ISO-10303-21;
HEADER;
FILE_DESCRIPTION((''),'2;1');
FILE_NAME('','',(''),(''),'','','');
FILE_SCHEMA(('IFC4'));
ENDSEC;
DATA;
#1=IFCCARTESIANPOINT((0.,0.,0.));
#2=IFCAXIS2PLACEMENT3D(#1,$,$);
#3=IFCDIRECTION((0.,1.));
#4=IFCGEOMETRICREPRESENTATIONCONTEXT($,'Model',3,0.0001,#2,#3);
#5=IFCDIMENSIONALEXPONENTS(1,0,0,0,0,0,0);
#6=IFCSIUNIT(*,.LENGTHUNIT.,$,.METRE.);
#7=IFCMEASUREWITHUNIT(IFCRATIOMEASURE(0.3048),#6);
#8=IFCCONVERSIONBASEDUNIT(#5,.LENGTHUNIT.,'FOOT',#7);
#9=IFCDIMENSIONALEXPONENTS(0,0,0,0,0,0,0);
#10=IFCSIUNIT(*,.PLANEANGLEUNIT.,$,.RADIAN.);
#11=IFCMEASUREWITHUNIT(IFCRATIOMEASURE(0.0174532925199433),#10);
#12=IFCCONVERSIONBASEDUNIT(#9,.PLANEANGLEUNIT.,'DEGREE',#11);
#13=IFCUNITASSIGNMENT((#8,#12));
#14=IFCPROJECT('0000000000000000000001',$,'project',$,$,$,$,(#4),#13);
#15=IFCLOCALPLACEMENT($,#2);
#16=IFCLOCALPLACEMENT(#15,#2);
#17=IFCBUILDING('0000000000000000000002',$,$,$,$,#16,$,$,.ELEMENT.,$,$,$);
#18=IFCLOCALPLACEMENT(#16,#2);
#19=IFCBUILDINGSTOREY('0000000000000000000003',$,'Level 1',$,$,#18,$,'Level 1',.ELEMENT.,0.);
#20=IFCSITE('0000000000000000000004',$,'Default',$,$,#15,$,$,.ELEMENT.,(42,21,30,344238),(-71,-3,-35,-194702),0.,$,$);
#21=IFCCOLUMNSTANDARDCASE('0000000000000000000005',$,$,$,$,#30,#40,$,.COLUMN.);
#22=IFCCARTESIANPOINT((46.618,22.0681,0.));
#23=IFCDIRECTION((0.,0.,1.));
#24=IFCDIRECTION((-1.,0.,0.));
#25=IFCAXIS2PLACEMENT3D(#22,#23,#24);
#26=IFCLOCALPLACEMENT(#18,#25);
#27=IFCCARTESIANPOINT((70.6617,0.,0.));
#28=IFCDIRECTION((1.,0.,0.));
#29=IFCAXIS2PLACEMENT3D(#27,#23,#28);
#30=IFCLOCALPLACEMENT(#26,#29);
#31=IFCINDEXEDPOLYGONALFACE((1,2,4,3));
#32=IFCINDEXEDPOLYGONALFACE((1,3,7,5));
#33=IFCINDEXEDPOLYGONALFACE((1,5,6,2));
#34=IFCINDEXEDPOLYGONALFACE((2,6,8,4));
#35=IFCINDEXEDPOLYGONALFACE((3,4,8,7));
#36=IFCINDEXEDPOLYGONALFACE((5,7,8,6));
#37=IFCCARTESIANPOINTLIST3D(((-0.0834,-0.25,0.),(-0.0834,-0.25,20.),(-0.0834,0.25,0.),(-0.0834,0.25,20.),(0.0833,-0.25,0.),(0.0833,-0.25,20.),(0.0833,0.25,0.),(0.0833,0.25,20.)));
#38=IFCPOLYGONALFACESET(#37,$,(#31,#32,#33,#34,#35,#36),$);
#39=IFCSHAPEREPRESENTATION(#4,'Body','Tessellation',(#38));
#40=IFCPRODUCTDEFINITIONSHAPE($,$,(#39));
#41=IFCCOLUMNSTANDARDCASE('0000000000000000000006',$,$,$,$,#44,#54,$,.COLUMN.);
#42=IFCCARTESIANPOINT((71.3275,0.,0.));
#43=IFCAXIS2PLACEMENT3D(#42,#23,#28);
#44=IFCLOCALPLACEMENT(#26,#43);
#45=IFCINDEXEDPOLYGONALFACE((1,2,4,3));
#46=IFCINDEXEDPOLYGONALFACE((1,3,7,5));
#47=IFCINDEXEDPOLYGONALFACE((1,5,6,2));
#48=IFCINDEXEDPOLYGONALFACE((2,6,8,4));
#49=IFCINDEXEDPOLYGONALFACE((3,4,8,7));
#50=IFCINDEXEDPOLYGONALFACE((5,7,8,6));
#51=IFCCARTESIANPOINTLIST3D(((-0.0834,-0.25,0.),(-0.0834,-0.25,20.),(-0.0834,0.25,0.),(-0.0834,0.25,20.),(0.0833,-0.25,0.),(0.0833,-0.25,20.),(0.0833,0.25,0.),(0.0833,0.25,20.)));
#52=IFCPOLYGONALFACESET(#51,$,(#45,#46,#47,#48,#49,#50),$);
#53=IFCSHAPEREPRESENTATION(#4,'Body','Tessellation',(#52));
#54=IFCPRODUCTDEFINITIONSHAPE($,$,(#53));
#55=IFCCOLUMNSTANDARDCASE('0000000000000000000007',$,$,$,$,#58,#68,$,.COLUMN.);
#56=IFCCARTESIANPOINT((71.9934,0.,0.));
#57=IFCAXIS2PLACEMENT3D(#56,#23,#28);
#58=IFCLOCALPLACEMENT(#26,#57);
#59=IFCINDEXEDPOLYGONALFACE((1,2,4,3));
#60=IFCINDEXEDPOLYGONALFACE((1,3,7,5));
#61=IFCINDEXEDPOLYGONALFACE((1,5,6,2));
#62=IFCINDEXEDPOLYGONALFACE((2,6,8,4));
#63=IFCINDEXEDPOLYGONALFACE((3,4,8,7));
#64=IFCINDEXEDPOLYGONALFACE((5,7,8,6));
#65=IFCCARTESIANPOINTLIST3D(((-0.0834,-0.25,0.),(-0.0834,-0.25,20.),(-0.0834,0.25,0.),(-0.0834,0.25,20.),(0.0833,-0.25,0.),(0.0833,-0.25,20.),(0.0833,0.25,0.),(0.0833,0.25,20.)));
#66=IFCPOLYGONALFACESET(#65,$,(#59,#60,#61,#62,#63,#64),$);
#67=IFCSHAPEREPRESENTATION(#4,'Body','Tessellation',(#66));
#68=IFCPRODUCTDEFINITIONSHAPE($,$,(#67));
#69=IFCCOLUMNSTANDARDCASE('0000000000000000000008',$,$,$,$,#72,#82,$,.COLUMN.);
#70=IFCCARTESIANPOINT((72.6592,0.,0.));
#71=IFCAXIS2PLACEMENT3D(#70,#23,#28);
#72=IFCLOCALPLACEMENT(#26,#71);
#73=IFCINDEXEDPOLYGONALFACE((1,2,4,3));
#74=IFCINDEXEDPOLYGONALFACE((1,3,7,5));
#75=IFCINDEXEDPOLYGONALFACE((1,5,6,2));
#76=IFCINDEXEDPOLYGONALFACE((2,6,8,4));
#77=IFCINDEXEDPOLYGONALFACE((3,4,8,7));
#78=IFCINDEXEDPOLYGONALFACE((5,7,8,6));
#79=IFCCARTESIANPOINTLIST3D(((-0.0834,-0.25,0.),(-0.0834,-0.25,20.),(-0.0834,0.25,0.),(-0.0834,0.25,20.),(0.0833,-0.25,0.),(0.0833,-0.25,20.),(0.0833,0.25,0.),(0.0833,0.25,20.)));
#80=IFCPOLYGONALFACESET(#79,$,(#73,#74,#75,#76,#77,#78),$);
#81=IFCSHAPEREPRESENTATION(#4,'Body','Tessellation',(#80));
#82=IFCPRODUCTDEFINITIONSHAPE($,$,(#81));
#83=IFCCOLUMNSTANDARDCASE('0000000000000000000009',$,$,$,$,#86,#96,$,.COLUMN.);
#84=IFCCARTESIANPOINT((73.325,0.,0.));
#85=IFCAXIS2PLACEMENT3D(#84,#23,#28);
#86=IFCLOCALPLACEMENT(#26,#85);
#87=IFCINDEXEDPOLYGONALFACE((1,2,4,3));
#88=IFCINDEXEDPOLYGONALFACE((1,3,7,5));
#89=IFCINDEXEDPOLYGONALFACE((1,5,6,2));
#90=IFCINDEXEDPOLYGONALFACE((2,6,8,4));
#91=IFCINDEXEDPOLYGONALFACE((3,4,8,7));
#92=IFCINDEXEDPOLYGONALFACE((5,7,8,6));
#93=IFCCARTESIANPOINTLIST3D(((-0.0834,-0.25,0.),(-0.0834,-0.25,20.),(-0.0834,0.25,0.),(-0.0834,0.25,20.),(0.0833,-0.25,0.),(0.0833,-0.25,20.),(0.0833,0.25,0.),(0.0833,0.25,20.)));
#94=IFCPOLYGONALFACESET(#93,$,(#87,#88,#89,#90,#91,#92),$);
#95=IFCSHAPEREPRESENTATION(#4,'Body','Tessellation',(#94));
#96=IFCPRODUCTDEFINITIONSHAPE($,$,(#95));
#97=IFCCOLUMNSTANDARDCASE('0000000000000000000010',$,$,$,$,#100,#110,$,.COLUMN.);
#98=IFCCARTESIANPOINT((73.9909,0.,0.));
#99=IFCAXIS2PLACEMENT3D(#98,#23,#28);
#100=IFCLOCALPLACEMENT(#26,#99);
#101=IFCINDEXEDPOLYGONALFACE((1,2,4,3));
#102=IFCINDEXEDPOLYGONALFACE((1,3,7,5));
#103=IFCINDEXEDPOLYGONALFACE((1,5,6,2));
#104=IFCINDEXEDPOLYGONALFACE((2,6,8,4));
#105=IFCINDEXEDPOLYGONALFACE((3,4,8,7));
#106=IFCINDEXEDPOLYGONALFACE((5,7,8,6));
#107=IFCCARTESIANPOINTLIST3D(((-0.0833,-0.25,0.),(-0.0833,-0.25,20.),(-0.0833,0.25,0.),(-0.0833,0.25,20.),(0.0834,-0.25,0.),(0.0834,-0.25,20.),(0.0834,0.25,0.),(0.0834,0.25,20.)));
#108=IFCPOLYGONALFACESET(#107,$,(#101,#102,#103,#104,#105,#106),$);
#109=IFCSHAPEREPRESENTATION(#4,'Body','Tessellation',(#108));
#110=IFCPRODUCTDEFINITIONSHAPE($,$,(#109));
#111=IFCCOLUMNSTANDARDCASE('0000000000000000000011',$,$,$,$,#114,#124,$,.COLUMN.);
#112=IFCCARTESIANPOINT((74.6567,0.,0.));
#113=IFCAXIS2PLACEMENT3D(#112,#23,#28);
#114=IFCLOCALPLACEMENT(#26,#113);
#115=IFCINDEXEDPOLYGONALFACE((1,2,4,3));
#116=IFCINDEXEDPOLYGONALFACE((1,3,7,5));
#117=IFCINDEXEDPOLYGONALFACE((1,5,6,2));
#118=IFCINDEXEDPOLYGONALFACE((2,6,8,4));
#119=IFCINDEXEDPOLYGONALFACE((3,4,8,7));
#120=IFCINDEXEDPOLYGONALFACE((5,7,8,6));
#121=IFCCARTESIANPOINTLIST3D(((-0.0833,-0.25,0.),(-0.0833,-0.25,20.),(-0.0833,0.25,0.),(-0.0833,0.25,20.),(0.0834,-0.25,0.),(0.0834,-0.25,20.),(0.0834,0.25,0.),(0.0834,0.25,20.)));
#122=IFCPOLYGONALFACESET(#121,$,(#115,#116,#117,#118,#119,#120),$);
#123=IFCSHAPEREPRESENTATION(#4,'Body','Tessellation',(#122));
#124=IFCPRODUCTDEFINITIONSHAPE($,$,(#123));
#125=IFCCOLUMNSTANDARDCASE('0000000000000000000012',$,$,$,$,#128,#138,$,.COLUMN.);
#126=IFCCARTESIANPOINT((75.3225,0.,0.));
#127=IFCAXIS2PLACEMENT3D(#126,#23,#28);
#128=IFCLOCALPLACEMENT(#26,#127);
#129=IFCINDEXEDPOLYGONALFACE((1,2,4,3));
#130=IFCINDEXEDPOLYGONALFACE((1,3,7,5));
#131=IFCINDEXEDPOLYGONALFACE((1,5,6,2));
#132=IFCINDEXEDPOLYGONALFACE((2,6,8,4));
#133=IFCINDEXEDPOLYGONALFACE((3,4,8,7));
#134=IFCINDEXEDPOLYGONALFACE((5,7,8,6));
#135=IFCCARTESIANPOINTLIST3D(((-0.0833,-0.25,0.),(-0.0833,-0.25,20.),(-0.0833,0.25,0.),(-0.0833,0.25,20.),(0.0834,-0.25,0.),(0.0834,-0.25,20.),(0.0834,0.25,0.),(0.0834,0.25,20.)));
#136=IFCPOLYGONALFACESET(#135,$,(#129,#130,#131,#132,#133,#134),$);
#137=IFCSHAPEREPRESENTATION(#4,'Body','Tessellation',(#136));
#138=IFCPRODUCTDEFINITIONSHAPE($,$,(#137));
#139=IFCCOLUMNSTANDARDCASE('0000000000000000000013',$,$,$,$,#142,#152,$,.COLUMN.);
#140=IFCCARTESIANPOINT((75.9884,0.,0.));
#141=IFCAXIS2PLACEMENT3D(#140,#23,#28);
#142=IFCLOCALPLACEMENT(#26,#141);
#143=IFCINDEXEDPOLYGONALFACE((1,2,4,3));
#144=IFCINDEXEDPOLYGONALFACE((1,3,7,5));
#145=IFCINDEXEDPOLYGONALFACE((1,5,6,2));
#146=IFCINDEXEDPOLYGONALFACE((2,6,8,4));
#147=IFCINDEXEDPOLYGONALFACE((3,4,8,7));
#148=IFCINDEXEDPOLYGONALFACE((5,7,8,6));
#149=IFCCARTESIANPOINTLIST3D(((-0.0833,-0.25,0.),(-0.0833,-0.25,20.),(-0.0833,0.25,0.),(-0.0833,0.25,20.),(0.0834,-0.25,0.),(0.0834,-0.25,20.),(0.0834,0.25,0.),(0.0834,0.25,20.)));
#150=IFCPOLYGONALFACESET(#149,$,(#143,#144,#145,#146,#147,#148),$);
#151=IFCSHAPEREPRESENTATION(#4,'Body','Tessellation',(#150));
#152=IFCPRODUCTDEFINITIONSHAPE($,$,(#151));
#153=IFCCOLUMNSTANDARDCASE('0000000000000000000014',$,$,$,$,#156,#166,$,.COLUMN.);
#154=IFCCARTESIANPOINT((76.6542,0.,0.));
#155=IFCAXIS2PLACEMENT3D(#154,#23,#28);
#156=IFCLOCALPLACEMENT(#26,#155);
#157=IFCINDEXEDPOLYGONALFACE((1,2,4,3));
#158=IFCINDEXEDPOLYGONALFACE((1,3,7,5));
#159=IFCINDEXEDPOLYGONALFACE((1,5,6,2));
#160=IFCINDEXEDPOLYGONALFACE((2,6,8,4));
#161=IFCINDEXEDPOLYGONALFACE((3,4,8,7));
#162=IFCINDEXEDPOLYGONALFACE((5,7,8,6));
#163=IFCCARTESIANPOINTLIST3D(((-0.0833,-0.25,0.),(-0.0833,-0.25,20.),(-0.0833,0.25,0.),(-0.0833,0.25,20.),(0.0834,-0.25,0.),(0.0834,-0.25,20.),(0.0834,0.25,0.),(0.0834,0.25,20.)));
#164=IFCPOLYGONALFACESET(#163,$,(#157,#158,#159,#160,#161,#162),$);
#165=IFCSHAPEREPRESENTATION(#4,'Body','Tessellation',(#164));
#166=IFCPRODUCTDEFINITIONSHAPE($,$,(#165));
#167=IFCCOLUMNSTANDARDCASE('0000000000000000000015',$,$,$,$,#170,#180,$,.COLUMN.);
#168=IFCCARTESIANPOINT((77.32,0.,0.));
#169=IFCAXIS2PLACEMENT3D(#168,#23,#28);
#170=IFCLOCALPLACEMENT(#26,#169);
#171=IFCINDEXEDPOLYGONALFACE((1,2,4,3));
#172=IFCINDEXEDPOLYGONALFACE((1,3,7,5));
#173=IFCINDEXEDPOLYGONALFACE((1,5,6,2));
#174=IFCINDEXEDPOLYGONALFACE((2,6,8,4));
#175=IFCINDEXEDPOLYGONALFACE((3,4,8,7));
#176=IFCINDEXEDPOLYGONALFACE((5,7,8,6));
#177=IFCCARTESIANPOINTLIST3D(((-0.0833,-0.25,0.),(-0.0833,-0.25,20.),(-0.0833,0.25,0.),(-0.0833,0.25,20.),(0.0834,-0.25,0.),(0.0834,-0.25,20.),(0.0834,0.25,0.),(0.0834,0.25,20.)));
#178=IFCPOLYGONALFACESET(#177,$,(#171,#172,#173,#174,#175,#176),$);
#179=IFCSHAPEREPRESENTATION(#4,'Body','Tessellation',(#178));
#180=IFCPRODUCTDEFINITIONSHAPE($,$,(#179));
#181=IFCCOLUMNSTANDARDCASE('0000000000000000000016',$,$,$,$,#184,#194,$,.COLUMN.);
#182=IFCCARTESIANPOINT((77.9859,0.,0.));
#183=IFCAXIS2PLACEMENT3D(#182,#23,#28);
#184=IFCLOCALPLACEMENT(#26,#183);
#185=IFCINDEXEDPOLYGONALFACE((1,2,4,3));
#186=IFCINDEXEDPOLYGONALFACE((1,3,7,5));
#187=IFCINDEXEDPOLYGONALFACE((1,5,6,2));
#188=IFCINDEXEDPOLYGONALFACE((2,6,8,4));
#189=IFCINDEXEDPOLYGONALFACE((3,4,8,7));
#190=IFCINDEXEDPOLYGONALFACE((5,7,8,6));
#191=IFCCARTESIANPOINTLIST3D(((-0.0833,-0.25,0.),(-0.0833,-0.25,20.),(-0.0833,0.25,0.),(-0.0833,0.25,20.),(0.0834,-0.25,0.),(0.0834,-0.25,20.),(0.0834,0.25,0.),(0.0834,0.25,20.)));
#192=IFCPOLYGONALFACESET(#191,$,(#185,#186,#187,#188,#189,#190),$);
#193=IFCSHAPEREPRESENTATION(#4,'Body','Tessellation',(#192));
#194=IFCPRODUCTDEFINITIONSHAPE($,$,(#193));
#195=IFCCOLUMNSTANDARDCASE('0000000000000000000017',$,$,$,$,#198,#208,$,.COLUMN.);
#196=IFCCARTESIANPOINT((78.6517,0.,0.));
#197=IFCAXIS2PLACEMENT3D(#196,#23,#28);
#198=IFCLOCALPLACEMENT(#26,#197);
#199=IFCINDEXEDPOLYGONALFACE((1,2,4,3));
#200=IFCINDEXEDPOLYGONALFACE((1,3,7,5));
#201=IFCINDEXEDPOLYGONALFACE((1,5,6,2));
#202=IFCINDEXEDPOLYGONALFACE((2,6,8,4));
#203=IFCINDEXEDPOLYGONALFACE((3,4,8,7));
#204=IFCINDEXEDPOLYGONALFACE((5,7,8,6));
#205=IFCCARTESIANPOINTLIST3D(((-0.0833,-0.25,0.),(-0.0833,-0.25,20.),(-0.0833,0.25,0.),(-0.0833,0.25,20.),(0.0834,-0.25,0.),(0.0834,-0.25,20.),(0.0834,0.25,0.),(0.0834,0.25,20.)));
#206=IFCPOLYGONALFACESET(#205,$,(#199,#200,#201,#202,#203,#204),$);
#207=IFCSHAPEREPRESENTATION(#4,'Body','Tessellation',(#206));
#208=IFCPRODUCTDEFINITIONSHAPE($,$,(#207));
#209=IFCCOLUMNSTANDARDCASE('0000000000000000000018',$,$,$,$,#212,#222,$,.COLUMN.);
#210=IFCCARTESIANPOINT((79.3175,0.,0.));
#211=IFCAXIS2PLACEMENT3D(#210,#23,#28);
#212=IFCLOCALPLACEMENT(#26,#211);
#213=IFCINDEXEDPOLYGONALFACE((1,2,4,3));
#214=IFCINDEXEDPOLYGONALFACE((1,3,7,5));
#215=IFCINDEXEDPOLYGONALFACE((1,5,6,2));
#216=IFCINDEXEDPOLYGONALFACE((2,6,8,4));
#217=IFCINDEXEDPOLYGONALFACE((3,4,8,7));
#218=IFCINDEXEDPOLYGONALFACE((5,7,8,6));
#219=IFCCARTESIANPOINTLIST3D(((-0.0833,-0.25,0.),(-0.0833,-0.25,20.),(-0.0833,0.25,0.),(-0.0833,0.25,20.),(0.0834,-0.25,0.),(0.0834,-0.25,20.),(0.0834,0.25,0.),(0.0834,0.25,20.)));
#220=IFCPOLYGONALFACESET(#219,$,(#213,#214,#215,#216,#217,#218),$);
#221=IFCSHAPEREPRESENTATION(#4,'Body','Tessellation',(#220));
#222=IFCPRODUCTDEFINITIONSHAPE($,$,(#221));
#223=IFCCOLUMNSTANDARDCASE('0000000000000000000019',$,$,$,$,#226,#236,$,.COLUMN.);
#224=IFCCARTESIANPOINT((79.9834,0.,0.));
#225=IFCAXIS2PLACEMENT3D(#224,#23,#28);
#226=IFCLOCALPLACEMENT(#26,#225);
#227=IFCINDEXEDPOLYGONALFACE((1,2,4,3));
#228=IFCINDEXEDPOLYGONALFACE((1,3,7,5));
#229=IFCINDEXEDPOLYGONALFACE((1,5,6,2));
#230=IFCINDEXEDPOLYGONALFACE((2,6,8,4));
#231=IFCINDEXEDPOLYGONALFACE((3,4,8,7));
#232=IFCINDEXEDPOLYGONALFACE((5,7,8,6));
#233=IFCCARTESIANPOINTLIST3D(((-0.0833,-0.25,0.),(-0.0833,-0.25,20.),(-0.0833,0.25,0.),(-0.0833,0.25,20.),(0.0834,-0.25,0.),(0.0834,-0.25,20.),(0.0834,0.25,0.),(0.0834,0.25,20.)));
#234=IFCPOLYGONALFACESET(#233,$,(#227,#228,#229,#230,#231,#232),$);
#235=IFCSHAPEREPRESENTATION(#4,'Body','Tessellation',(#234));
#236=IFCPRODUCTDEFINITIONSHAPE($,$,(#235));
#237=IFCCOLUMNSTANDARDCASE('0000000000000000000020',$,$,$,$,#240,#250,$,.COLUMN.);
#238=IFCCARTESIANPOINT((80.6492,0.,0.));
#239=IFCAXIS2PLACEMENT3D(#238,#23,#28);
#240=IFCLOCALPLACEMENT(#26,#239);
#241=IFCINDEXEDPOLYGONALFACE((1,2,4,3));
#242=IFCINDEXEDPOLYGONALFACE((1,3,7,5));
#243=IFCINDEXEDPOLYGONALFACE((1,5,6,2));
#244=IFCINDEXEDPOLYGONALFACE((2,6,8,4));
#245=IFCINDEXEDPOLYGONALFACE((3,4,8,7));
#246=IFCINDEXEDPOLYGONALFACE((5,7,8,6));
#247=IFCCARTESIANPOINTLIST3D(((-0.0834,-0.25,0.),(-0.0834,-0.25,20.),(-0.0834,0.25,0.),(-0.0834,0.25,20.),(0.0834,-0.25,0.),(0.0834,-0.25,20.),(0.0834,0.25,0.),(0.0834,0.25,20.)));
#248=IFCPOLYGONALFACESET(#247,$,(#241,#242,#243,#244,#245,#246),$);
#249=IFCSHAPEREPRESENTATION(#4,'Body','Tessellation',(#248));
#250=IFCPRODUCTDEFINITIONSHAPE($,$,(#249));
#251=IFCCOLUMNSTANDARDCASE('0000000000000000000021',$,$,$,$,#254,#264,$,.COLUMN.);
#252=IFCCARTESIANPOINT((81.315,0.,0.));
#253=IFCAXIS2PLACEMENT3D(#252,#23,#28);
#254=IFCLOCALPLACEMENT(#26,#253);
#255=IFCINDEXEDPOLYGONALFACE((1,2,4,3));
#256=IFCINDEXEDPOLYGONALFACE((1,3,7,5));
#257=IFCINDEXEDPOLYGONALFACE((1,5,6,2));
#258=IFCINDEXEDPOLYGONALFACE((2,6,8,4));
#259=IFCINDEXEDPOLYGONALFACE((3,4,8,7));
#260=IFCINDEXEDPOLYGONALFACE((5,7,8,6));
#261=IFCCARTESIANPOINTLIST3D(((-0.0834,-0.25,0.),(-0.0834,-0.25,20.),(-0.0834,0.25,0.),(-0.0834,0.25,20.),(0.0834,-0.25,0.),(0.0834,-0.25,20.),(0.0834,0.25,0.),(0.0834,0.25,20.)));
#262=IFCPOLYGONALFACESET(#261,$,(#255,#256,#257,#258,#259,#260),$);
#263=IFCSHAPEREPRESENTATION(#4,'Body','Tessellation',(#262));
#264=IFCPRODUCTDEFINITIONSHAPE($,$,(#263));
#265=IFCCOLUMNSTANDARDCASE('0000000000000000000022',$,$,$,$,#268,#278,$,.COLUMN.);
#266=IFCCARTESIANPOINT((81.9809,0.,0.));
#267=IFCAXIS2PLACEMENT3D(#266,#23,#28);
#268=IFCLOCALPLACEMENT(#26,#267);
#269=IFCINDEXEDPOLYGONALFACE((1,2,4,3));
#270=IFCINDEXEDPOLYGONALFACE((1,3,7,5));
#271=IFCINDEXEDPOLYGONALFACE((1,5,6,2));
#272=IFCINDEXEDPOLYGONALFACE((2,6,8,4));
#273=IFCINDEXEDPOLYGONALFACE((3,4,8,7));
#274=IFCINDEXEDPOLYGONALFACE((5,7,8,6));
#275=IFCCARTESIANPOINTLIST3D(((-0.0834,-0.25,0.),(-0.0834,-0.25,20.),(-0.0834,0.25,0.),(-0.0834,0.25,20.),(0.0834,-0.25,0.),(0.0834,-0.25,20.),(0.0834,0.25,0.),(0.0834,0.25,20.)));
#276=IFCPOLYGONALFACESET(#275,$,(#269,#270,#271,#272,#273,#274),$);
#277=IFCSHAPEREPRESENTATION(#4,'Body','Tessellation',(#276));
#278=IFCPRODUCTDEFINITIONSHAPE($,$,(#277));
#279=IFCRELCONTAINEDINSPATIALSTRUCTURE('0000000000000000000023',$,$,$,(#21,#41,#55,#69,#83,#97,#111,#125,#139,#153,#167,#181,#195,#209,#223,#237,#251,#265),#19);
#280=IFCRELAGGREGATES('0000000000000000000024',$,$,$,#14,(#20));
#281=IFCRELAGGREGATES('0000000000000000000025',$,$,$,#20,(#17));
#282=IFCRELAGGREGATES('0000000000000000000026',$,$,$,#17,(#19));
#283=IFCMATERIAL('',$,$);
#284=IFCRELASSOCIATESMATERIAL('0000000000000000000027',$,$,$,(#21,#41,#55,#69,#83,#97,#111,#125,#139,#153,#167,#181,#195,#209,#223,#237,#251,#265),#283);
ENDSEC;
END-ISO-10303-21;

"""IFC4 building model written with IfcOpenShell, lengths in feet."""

from ifc_helpers import new_model, entity, si_unit, converted_unit, direction, frame, origin, place, context, project, spatial, rectangle, extrude, material, element, save


model = new_model("IFC4")

# Units and contexts
model_context = context("Model", 3, precision=0.0001, world=origin(), true_north=direction((0.0, 1.0)))
ifc_project = project(units=[converted_unit("LENGTHUNIT", "FOOT", entity("IfcRatioMeasure", 0.3048), si_unit("LENGTHUNIT", "METRE"), dimensions=[1, 0, 0, 0, 0, 0, 0]), converted_unit("PLANEANGLEUNIT", "DEGREE", entity("IfcRatioMeasure", 0.0174532925199433), si_unit("PLANEANGLEUNIT", "RADIAN"), dimensions=[0, 0, 0, 0, 0, 0, 0])], contexts=[model_context])

# Site, building, storey
site_placement = place(None, origin())
site = spatial("IfcSite", under=ifc_project, at=site_placement, Name="Default", CompositionType="ELEMENT", RefLatitude=(42, 21, 30, 344238), RefLongitude=(-71, -3, -35, -194702), RefElevation=0.0)
building_placement = place(site_placement, origin())
building = spatial("IfcBuilding", under=site, at=building_placement, CompositionType="ELEMENT")
storey_placement = place(building_placement, origin())
storey = spatial("IfcBuildingStorey", under=building, at=storey_placement, Name="Level 1", LongName="Level 1", CompositionType="ELEMENT", Elevation=0.0)

# Columns
ifc_material = material(Name="")
placement = place(storey_placement, frame((46.618, 22.0681, 0.0), z_axis=(0.0, 0.0, 1.0), x_axis=(-1.0, 0.0, 0.0)))
for number, where, z_axis, x_axis in (
    (1, (70.6617, 0.0, 0.0), (0.0, 0.0, 1.0), (1.0, 0.0, 0.0)),
    (2, (71.3275, 0.0, 0.0), (0.0, 0.0, 1.0), (1.0, 0.0, 0.0)),
    (3, (71.9934, 0.0, 0.0), (0.0, 0.0, 1.0), (1.0, 0.0, 0.0)),
    (4, (72.6592, 0.0, 0.0), (0.0, 0.0, 1.0), (1.0, 0.0, 0.0)),
    (5, (73.325, 0.0, 0.0), (0.0, 0.0, 1.0), (1.0, 0.0, 0.0)),
    (6, (73.9909, 0.0, 0.0), (0.0, 0.0, 1.0), (1.0, 0.0, 0.0)),
    (7, (74.6567, 0.0, 0.0), (0.0, 0.0, 1.0), (1.0, 0.0, 0.0)),
    (8, (75.3225, 0.0, 0.0), (0.0, 0.0, 1.0), (1.0, 0.0, 0.0)),
    (9, (75.9884, 0.0, 0.0), (0.0, 0.0, 1.0), (1.0, 0.0, 0.0)),
    (10, (76.6542, 0.0, 0.0), (0.0, 0.0, 1.0), (1.0, 0.0, 0.0)),
    (11, (77.32, 0.0, 0.0), (0.0, 0.0, 1.0), (1.0, 0.0, 0.0)),
    (12, (77.9859, 0.0, 0.0), (0.0, 0.0, 1.0), (1.0, 0.0, 0.0)),
    (13, (78.6517, 0.0, 0.0), (0.0, 0.0, 1.0), (1.0, 0.0, 0.0)),
    (14, (79.3175, 0.0, 0.0), (0.0, 0.0, 1.0), (1.0, 0.0, 0.0)),
    (15, (79.9834, 0.0, 0.0), (0.0, 0.0, 1.0), (1.0, 0.0, 0.0)),
    (16, (80.6492, 0.0, 0.0), (0.0, 0.0, 1.0), (1.0, 0.0, 0.0)),
    (17, (81.315, 0.0, 0.0), (0.0, 0.0, 1.0), (1.0, 0.0, 0.0)),
    (18, (81.9809, 0.0, 0.0), (0.0, 0.0, 1.0), (1.0, 0.0, 0.0)),
):
    element("IfcColumnStandardCase", number, at=place(placement, frame(where, z_axis=z_axis, x_axis=x_axis)), inside=storey, material=ifc_material, PredefinedType="COLUMN", context=model_context, shape_type="SweptSolid", body=[
        extrude(rectangle(XDim=0.1667, YDim=0.5), origin(), (0.0, 0.0, 1.0), 20.0),
    ])

save(model, "model.ifc")
